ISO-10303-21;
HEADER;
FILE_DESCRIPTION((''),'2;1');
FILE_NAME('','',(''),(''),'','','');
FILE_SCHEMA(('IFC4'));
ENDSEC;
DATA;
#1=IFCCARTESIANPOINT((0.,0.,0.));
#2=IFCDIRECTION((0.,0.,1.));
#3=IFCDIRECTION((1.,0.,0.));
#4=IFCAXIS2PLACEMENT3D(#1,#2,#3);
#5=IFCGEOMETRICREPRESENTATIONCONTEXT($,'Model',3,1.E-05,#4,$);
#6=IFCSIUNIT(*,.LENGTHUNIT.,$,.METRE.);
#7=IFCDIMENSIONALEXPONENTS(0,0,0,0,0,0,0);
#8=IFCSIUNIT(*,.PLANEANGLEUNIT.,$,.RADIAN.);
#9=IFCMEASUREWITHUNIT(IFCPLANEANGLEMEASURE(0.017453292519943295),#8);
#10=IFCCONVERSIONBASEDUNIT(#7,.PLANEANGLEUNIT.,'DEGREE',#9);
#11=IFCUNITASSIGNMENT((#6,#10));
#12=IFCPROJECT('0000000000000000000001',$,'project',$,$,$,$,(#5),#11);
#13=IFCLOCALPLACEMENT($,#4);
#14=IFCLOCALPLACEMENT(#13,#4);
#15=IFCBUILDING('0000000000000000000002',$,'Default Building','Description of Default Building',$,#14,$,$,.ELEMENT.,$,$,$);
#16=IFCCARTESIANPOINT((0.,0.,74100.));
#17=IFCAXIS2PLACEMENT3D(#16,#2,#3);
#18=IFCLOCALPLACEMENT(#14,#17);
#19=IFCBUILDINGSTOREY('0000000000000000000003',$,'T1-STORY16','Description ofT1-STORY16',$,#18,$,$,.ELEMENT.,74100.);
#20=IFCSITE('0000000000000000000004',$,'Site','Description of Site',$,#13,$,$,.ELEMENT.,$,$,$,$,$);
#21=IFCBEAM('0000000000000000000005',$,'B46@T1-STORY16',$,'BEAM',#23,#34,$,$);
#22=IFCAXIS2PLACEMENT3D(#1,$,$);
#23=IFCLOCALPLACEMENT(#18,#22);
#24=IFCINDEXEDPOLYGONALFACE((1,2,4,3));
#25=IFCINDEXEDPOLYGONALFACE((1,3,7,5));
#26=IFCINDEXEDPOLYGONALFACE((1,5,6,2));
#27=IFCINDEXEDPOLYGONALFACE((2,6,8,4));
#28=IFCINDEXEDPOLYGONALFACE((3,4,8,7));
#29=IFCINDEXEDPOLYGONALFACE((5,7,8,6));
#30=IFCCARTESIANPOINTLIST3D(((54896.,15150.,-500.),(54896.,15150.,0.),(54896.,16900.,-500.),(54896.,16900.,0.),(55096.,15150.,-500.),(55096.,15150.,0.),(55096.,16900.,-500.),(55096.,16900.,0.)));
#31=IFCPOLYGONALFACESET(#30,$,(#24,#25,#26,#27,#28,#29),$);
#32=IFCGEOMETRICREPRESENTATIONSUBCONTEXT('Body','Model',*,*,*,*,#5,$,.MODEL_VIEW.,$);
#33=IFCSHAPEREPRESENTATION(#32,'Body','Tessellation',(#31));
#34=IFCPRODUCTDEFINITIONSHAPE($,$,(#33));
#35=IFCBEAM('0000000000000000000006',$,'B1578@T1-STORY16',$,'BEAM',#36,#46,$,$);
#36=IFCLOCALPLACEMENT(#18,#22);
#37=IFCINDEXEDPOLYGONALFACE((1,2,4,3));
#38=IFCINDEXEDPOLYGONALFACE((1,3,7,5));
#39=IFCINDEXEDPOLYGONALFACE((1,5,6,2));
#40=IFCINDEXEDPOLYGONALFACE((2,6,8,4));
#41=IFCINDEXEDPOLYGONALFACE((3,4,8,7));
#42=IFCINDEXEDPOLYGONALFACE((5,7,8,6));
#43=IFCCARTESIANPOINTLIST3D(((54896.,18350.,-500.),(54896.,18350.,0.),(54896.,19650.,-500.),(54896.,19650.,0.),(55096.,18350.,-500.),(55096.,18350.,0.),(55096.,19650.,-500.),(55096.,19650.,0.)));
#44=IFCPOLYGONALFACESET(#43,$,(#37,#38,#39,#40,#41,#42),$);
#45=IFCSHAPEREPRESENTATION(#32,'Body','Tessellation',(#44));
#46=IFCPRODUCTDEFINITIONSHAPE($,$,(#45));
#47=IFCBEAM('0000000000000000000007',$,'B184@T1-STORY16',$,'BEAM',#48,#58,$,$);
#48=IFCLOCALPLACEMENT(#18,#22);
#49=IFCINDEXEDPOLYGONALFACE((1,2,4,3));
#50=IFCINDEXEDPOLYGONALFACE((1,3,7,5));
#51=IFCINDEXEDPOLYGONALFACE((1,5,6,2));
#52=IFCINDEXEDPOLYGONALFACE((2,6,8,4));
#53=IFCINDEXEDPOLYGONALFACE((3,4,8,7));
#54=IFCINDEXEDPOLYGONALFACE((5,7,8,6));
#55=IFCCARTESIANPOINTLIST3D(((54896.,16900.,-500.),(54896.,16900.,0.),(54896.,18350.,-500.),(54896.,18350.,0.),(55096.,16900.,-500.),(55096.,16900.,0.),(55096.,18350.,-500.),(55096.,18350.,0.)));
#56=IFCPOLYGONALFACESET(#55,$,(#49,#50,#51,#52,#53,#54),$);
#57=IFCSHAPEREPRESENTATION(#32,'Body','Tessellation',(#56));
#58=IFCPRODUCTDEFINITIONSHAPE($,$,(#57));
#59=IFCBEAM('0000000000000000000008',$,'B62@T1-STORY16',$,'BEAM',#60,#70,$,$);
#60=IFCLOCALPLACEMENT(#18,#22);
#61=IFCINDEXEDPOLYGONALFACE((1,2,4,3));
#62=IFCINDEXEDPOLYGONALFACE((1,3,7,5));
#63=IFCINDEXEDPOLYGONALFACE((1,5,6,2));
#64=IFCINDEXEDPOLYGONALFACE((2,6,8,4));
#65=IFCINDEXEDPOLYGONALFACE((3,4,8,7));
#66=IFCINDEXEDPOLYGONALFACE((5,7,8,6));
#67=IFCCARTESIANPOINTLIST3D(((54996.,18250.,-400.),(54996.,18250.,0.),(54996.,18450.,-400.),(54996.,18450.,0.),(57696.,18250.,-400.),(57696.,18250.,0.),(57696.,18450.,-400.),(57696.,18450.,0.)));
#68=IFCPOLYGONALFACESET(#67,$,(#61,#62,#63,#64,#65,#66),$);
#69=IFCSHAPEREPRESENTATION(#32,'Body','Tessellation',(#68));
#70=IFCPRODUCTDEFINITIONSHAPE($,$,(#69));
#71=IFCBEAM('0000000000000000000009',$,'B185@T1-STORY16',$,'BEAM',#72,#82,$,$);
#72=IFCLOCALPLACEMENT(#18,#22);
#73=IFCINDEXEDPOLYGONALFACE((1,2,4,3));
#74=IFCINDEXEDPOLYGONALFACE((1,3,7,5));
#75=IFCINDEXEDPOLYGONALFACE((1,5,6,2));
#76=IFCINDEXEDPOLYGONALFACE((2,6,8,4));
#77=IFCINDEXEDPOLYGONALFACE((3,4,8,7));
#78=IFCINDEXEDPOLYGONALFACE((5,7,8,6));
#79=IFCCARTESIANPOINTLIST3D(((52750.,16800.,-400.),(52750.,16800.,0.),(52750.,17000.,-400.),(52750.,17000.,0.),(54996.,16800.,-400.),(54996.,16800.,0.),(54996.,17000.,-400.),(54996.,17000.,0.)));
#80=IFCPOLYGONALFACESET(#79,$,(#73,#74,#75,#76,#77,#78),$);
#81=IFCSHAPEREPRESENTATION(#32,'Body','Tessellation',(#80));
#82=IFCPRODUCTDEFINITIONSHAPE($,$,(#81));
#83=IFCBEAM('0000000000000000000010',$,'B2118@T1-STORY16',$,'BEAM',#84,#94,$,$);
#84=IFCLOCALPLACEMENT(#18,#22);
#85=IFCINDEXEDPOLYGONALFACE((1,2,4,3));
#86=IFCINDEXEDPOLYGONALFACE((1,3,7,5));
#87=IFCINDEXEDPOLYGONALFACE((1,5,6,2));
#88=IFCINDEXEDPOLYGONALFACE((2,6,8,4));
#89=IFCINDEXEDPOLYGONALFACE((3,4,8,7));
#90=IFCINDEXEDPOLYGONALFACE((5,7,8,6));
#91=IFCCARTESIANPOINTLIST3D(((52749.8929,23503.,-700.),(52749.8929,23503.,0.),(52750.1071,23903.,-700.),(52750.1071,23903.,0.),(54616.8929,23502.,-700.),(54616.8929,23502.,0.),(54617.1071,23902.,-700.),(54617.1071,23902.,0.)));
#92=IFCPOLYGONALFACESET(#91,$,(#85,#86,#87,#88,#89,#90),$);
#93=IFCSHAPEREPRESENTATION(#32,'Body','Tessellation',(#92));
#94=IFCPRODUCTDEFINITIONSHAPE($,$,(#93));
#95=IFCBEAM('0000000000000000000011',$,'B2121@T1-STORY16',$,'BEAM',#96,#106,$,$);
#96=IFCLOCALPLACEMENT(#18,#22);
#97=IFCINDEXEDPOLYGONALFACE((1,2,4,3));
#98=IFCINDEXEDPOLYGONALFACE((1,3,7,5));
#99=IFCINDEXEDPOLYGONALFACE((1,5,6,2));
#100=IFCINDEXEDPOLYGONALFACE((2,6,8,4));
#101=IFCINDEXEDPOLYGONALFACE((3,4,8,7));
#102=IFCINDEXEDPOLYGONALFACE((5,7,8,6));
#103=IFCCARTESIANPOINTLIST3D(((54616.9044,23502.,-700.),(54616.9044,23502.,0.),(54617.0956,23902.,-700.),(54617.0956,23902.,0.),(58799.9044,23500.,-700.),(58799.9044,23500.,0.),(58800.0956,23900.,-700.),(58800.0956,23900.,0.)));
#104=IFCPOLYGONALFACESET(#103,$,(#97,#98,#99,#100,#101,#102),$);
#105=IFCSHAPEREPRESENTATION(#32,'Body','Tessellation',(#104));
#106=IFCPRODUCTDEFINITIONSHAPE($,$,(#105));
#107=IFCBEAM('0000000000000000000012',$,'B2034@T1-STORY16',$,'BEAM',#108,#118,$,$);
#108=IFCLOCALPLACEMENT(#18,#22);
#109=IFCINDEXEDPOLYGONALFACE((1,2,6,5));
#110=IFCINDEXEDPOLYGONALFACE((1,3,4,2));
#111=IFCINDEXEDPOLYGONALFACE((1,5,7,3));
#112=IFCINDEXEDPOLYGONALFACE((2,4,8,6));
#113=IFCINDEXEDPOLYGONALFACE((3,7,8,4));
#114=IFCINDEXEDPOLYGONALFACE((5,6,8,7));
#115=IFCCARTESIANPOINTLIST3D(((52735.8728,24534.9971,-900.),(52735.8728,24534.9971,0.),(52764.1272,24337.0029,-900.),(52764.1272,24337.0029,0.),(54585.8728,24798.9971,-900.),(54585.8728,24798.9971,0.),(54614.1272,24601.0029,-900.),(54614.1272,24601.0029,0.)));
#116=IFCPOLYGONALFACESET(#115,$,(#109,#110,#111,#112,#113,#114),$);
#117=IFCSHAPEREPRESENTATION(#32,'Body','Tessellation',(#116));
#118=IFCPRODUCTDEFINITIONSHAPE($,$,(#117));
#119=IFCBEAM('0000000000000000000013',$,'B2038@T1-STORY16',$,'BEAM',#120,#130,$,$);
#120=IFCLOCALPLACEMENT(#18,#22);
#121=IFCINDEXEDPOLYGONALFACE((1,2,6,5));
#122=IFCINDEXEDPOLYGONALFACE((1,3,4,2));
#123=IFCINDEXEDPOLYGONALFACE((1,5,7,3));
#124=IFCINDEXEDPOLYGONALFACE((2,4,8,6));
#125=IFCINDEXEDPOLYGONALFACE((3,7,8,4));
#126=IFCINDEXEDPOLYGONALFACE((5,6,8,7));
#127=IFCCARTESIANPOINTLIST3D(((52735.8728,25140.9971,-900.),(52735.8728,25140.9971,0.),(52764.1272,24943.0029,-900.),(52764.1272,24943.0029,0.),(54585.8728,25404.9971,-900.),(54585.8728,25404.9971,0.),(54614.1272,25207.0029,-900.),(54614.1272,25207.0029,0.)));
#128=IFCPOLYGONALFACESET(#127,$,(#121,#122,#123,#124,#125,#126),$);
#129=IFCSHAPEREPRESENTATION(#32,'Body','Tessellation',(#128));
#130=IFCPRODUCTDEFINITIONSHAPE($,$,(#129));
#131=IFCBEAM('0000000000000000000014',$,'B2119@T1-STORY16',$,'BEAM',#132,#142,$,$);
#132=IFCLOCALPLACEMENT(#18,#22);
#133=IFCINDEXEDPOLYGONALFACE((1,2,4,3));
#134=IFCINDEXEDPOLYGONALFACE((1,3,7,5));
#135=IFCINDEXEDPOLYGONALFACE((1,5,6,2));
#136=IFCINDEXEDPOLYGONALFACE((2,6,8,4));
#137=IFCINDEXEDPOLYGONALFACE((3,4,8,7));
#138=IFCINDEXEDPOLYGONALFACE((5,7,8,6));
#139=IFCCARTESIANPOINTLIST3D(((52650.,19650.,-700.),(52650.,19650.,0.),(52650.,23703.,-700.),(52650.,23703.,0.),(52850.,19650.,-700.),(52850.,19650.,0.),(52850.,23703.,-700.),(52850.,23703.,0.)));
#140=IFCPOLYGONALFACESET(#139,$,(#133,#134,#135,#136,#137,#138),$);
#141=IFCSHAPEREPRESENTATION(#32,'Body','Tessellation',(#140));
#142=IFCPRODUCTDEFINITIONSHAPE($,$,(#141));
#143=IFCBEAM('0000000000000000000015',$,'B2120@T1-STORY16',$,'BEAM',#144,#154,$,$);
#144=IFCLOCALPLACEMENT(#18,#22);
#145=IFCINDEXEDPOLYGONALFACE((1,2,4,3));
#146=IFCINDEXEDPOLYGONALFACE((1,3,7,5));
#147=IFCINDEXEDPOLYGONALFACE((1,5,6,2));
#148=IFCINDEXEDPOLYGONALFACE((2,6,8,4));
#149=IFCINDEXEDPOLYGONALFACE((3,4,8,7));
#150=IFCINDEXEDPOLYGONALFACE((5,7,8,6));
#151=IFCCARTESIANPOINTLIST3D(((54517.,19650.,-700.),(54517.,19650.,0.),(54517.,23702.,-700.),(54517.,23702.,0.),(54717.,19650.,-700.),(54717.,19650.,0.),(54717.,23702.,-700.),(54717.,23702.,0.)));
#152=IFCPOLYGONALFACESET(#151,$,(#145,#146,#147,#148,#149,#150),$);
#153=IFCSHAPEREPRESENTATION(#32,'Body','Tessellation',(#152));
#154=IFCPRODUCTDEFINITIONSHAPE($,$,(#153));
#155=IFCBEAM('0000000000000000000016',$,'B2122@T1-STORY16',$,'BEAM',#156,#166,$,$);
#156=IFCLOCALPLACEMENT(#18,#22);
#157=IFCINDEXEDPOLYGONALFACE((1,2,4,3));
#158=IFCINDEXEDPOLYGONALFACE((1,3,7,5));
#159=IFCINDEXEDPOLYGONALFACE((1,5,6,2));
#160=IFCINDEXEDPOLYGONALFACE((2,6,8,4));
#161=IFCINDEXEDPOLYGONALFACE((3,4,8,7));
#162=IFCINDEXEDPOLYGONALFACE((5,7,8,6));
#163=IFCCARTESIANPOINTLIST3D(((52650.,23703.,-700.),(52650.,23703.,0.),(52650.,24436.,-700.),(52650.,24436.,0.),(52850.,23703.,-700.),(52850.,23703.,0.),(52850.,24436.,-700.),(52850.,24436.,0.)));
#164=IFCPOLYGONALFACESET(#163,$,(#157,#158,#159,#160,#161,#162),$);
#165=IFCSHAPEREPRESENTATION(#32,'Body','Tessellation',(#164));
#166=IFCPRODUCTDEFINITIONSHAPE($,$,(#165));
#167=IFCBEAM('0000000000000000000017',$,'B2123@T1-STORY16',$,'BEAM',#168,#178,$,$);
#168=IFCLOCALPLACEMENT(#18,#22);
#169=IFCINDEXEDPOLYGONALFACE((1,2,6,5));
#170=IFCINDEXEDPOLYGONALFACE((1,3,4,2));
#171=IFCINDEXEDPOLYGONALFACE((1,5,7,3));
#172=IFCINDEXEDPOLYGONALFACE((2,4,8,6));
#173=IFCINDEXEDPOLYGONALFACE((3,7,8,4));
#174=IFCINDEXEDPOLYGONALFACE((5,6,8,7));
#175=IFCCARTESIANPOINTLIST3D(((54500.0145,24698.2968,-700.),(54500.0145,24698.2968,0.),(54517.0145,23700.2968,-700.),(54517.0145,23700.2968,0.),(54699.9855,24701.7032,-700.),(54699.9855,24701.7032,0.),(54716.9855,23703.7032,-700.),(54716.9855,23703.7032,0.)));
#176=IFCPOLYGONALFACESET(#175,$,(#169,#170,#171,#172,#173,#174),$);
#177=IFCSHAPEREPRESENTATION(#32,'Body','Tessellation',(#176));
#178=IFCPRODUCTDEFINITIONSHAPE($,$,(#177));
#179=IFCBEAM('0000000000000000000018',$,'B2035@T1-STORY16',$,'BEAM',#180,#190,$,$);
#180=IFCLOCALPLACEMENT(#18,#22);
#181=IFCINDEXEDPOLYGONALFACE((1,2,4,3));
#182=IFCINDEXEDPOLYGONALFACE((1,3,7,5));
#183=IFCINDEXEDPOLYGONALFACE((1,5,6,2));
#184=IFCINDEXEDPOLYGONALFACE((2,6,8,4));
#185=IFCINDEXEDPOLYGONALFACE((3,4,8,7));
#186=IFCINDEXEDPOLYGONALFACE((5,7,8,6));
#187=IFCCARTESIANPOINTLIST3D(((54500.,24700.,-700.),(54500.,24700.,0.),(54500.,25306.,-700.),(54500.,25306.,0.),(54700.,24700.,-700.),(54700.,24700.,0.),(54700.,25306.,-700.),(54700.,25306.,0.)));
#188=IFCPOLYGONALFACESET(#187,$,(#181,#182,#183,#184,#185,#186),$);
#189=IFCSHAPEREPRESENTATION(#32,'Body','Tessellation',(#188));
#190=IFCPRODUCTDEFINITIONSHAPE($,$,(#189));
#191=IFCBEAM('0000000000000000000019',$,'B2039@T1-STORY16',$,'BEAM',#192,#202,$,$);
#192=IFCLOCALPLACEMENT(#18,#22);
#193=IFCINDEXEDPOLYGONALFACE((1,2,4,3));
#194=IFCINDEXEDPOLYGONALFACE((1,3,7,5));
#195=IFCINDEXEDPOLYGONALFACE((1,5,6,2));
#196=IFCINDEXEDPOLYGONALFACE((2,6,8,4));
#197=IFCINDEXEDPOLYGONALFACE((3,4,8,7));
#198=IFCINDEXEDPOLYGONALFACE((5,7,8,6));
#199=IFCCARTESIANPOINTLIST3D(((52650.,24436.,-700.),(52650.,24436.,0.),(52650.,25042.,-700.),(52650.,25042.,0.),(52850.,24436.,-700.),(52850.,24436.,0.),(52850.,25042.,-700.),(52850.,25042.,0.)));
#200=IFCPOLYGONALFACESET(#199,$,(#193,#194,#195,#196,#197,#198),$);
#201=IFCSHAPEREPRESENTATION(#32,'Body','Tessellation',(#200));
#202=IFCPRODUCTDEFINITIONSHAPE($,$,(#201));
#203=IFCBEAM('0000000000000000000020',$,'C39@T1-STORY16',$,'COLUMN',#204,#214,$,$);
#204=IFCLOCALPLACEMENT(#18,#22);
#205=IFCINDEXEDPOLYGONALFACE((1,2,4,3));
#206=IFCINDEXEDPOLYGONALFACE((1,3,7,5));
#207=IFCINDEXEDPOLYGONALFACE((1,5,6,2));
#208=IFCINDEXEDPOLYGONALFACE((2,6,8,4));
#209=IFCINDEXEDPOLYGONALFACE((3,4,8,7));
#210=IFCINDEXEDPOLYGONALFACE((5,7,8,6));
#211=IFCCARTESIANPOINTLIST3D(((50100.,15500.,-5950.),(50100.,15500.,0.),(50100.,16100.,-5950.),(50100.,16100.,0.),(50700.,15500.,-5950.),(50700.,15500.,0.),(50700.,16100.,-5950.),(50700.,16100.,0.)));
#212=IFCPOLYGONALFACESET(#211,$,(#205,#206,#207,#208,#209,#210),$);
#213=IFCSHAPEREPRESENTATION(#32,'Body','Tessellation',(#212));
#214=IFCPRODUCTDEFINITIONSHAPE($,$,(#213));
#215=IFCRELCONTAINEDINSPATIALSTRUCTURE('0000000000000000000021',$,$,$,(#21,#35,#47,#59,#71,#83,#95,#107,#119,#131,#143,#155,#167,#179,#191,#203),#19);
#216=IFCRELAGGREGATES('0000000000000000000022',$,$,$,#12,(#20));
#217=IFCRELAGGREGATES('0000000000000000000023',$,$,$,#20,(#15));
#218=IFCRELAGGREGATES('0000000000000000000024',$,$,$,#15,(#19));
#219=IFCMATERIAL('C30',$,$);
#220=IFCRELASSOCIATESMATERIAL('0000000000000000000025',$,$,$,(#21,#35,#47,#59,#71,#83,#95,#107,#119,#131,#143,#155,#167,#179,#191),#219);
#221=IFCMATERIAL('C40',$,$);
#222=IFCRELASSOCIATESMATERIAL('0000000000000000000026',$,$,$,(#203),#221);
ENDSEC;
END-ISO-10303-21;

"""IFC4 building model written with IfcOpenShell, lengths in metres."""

from ifc_helpers import new_model, entity, si_unit, converted_unit, frame, origin_with_axes, place, context, subcontext, project, spatial, rectangle, extrude, material, element, save


model = new_model("IFC4")

# Units and contexts
model_context = context("Model", 3, precision=1e-05, world=origin_with_axes())
body_context = subcontext(model_context, "Body", "Model", "MODEL_VIEW")
ifc_project = project(units=[si_unit("LENGTHUNIT", "METRE"), converted_unit("PLANEANGLEUNIT", "DEGREE", entity("IfcPlaneAngleMeasure", 0.017453292519943295), si_unit("PLANEANGLEUNIT", "RADIAN"), dimensions=[0, 0, 0, 0, 0, 0, 0])], contexts=[model_context])

# Site, building, storey
site_placement = place(None, origin_with_axes())
site = spatial("IfcSite", under=ifc_project, at=site_placement, Name="Site", Description="Description of Site", CompositionType="ELEMENT")
building_placement = place(site_placement, origin_with_axes())
building = spatial("IfcBuilding", under=site, at=building_placement, Name="Default Building", Description="Description of Default Building", CompositionType="ELEMENT")
storey_placement = place(building_placement, frame((0.0, 0.0, 74100.0), z_axis=(0.0, 0.0, 1.0), x_axis=(1.0, 0.0, 0.0)))
storey = spatial("IfcBuildingStorey", under=building, at=storey_placement, Name="T1-STORY16", Description="Description ofT1-STORY16", CompositionType="ELEMENT", Elevation=74100.0)

# Beams
ifc_material_1 = material(Name="C30")
beam_1_placement = place(storey_placement, frame((54996.0, 15150.0, -250.0), z_axis=(0.0, 1.0, 0.0), x_axis=(-1.0, 0.0, 0.0)))
element("IfcBeam", 1, at=beam_1_placement, inside=storey, material=ifc_material_1, Name="B46@T1-STORY16", ObjectType="BEAM", context=body_context, shape_type="SweptSolid", body=[
    extrude(rectangle(XDim=200.0, YDim=500.0), origin_with_axes(), (0.0, 0.0, 1.0), 1750.0),
])
beam_2_placement = place(storey_placement, frame((54996.0, 18350.0, -250.0), z_axis=(0.0, 1.0, 0.0), x_axis=(-1.0, 0.0, 0.0)))
element("IfcBeam", 2, at=beam_2_placement, inside=storey, material=ifc_material_1, Name="B1578@T1-STORY16", ObjectType="BEAM", context=body_context, shape_type="SweptSolid", body=[
    extrude(rectangle(XDim=200.0, YDim=500.0), origin_with_axes(), (0.0, 0.0, 1.0), 1300.0),
])
beam_3_placement = place(storey_placement, frame((54996.0, 16900.0, -250.0), z_axis=(0.0, 1.0, 0.0), x_axis=(-1.0, 0.0, 0.0)))
element("IfcBeam", 3, at=beam_3_placement, inside=storey, material=ifc_material_1, Name="B184@T1-STORY16", ObjectType="BEAM", context=body_context, shape_type="SweptSolid", body=[
    extrude(rectangle(XDim=200.0, YDim=500.0), origin_with_axes(), (0.0, 0.0, 1.0), 1450.0),
])
beam_4_placement = place(storey_placement, frame((54996.0, 18350.0, -200.0), z_axis=(1.0, 0.0, 0.0), x_axis=(0.0, 1.0, 0.0)))
element("IfcBeam", 4, at=beam_4_placement, inside=storey, material=ifc_material_1, Name="B62@T1-STORY16", ObjectType="BEAM", context=body_context, shape_type="SweptSolid", body=[
    extrude(rectangle(XDim=200.0, YDim=400.0), origin_with_axes(), (0.0, 0.0, 1.0), 2700.0),
])
beam_5_placement = place(storey_placement, frame((52750.0, 16900.0, -200.0), z_axis=(1.0, 0.0, 0.0), x_axis=(0.0, 1.0, 0.0)))
element("IfcBeam", 5, at=beam_5_placement, inside=storey, material=ifc_material_1, Name="B185@T1-STORY16", ObjectType="BEAM", context=body_context, shape_type="SweptSolid", body=[
    extrude(rectangle(XDim=200.0, YDim=400.0), origin_with_axes(), (0.0, 0.0, 1.0), 2246.0),
])
beam_6_placement = place(storey_placement, frame((52750.0, 23703.0, -350.0), z_axis=(1.0, -0.000536, 0.0), x_axis=(0.000536, 1.0, 0.0)))
element("IfcBeam", 6, at=beam_6_placement, inside=storey, material=ifc_material_1, Name="B2118@T1-STORY16", ObjectType="BEAM", context=body_context, shape_type="SweptSolid", body=[
    extrude(rectangle(XDim=400.0, YDim=700.0), origin_with_axes(), (0.0, 0.0, 1.0), 1867.0003),
])
beam_7_placement = place(storey_placement, frame((54617.0, 23702.0, -350.0), z_axis=(1.0, -0.000478, 0.0), x_axis=(0.000478, 1.0, 0.0)))
element("IfcBeam", 7, at=beam_7_placement, inside=storey, material=ifc_material_1, Name="B2121@T1-STORY16", ObjectType="BEAM", context=body_context, shape_type="SweptSolid", body=[
    extrude(rectangle(XDim=400.0, YDim=700.0), origin_with_axes(), (0.0, 0.0, 1.0), 4183.0005),
])
for number, where, z_axis, x_axis, name in (
    (8, (52750.0, 24436.0, -450.0), (0.989971, 0.141272, 0.0), (-0.141272, 0.989971, 0.0), "B2034@T1-STORY16"),
    (9, (52750.0, 25042.0, -450.0), (0.989971, 0.141272, 0.0), (-0.141272, 0.989971, 0.0), "B2038@T1-STORY16"),
):
    element("IfcBeam", number, at=place(storey_placement, frame(where, z_axis=z_axis, x_axis=x_axis)), inside=storey, material=ifc_material_1, Name=name, ObjectType="BEAM", context=body_context, shape_type="SweptSolid", body=[
        extrude(rectangle(XDim=200.0, YDim=900.0), origin_with_axes(), (0.0, 0.0, 1.0), 1868.7418),
    ])
beam_8_placement = place(storey_placement, frame((52750.0, 19650.0, -350.0), z_axis=(0.0, 1.0, 0.0), x_axis=(-1.0, 0.0, 0.0)))
element("IfcBeam", 10, at=beam_8_placement, inside=storey, material=ifc_material_1, Name="B2119@T1-STORY16", ObjectType="BEAM", context=body_context, shape_type="SweptSolid", body=[
    extrude(rectangle(XDim=200.0, YDim=700.0), origin_with_axes(), (0.0, 0.0, 1.0), 4053.0),
])
beam_9_placement = place(storey_placement, frame((54617.0, 19650.0, -350.0), z_axis=(0.0, 1.0, 0.0), x_axis=(-1.0, 0.0, 0.0)))
element("IfcBeam", 11, at=beam_9_placement, inside=storey, material=ifc_material_1, Name="B2120@T1-STORY16", ObjectType="BEAM", context=body_context, shape_type="SweptSolid", body=[
    extrude(rectangle(XDim=200.0, YDim=700.0), origin_with_axes(), (0.0, 0.0, 1.0), 4052.0),
])
beam_10_placement = place(storey_placement, frame((52750.0, 23703.0, -350.0), z_axis=(0.0, 1.0, 0.0), x_axis=(-1.0, 0.0, 0.0)))
element("IfcBeam", 12, at=beam_10_placement, inside=storey, material=ifc_material_1, Name="B2122@T1-STORY16", ObjectType="BEAM", context=body_context, shape_type="SweptSolid", body=[
    extrude(rectangle(XDim=200.0, YDim=700.0), origin_with_axes(), (0.0, 0.0, 1.0), 733.0),
])
beam_11_placement = place(storey_placement, frame((54600.0, 24700.0, -350.0), z_axis=(0.017032, -0.999855, 0.0), x_axis=(0.999855, 0.017032, 0.0)))
element("IfcBeam", 13, at=beam_11_placement, inside=storey, material=ifc_material_1, Name="B2123@T1-STORY16", ObjectType="BEAM", context=body_context, shape_type="SweptSolid", body=[
    extrude(rectangle(XDim=200.0, YDim=700.0), origin_with_axes(), (0.0, 0.0, 1.0), 998.1448),
])
for number, where, z_axis, x_axis, name in (
    (14, (54600.0, 24700.0, -350.0), (0.0, 1.0, 0.0), (-1.0, 0.0, 0.0), "B2035@T1-STORY16"),
    (15, (52750.0, 24436.0, -350.0), (0.0, 1.0, 0.0), (-1.0, 0.0, 0.0), "B2039@T1-STORY16"),
):
    element("IfcBeam", number, at=place(storey_placement, frame(where, z_axis=z_axis, x_axis=x_axis)), inside=storey, material=ifc_material_1, Name=name, ObjectType="BEAM", context=body_context, shape_type="SweptSolid", body=[
        extrude(rectangle(XDim=200.0, YDim=700.0), origin_with_axes(), (0.0, 0.0, 1.0), 606.0),
    ])
ifc_material_2 = material(Name="C40")
beam_12_placement = place(storey_placement, frame((50400.0, 15800.0, -5950.0), z_axis=(0.0, 0.0, 1.0), x_axis=(-1.0, 0.0, 0.0)))
element("IfcBeam", 16, at=beam_12_placement, inside=storey, material=ifc_material_2, Name="C39@T1-STORY16", ObjectType="COLUMN", context=body_context, shape_type="SweptSolid", body=[
    extrude(rectangle(XDim=600.0, YDim=600.0), origin_with_axes(), (0.0, 0.0, 1.0), 5950.0),
])

save(model, "model.ifc")
